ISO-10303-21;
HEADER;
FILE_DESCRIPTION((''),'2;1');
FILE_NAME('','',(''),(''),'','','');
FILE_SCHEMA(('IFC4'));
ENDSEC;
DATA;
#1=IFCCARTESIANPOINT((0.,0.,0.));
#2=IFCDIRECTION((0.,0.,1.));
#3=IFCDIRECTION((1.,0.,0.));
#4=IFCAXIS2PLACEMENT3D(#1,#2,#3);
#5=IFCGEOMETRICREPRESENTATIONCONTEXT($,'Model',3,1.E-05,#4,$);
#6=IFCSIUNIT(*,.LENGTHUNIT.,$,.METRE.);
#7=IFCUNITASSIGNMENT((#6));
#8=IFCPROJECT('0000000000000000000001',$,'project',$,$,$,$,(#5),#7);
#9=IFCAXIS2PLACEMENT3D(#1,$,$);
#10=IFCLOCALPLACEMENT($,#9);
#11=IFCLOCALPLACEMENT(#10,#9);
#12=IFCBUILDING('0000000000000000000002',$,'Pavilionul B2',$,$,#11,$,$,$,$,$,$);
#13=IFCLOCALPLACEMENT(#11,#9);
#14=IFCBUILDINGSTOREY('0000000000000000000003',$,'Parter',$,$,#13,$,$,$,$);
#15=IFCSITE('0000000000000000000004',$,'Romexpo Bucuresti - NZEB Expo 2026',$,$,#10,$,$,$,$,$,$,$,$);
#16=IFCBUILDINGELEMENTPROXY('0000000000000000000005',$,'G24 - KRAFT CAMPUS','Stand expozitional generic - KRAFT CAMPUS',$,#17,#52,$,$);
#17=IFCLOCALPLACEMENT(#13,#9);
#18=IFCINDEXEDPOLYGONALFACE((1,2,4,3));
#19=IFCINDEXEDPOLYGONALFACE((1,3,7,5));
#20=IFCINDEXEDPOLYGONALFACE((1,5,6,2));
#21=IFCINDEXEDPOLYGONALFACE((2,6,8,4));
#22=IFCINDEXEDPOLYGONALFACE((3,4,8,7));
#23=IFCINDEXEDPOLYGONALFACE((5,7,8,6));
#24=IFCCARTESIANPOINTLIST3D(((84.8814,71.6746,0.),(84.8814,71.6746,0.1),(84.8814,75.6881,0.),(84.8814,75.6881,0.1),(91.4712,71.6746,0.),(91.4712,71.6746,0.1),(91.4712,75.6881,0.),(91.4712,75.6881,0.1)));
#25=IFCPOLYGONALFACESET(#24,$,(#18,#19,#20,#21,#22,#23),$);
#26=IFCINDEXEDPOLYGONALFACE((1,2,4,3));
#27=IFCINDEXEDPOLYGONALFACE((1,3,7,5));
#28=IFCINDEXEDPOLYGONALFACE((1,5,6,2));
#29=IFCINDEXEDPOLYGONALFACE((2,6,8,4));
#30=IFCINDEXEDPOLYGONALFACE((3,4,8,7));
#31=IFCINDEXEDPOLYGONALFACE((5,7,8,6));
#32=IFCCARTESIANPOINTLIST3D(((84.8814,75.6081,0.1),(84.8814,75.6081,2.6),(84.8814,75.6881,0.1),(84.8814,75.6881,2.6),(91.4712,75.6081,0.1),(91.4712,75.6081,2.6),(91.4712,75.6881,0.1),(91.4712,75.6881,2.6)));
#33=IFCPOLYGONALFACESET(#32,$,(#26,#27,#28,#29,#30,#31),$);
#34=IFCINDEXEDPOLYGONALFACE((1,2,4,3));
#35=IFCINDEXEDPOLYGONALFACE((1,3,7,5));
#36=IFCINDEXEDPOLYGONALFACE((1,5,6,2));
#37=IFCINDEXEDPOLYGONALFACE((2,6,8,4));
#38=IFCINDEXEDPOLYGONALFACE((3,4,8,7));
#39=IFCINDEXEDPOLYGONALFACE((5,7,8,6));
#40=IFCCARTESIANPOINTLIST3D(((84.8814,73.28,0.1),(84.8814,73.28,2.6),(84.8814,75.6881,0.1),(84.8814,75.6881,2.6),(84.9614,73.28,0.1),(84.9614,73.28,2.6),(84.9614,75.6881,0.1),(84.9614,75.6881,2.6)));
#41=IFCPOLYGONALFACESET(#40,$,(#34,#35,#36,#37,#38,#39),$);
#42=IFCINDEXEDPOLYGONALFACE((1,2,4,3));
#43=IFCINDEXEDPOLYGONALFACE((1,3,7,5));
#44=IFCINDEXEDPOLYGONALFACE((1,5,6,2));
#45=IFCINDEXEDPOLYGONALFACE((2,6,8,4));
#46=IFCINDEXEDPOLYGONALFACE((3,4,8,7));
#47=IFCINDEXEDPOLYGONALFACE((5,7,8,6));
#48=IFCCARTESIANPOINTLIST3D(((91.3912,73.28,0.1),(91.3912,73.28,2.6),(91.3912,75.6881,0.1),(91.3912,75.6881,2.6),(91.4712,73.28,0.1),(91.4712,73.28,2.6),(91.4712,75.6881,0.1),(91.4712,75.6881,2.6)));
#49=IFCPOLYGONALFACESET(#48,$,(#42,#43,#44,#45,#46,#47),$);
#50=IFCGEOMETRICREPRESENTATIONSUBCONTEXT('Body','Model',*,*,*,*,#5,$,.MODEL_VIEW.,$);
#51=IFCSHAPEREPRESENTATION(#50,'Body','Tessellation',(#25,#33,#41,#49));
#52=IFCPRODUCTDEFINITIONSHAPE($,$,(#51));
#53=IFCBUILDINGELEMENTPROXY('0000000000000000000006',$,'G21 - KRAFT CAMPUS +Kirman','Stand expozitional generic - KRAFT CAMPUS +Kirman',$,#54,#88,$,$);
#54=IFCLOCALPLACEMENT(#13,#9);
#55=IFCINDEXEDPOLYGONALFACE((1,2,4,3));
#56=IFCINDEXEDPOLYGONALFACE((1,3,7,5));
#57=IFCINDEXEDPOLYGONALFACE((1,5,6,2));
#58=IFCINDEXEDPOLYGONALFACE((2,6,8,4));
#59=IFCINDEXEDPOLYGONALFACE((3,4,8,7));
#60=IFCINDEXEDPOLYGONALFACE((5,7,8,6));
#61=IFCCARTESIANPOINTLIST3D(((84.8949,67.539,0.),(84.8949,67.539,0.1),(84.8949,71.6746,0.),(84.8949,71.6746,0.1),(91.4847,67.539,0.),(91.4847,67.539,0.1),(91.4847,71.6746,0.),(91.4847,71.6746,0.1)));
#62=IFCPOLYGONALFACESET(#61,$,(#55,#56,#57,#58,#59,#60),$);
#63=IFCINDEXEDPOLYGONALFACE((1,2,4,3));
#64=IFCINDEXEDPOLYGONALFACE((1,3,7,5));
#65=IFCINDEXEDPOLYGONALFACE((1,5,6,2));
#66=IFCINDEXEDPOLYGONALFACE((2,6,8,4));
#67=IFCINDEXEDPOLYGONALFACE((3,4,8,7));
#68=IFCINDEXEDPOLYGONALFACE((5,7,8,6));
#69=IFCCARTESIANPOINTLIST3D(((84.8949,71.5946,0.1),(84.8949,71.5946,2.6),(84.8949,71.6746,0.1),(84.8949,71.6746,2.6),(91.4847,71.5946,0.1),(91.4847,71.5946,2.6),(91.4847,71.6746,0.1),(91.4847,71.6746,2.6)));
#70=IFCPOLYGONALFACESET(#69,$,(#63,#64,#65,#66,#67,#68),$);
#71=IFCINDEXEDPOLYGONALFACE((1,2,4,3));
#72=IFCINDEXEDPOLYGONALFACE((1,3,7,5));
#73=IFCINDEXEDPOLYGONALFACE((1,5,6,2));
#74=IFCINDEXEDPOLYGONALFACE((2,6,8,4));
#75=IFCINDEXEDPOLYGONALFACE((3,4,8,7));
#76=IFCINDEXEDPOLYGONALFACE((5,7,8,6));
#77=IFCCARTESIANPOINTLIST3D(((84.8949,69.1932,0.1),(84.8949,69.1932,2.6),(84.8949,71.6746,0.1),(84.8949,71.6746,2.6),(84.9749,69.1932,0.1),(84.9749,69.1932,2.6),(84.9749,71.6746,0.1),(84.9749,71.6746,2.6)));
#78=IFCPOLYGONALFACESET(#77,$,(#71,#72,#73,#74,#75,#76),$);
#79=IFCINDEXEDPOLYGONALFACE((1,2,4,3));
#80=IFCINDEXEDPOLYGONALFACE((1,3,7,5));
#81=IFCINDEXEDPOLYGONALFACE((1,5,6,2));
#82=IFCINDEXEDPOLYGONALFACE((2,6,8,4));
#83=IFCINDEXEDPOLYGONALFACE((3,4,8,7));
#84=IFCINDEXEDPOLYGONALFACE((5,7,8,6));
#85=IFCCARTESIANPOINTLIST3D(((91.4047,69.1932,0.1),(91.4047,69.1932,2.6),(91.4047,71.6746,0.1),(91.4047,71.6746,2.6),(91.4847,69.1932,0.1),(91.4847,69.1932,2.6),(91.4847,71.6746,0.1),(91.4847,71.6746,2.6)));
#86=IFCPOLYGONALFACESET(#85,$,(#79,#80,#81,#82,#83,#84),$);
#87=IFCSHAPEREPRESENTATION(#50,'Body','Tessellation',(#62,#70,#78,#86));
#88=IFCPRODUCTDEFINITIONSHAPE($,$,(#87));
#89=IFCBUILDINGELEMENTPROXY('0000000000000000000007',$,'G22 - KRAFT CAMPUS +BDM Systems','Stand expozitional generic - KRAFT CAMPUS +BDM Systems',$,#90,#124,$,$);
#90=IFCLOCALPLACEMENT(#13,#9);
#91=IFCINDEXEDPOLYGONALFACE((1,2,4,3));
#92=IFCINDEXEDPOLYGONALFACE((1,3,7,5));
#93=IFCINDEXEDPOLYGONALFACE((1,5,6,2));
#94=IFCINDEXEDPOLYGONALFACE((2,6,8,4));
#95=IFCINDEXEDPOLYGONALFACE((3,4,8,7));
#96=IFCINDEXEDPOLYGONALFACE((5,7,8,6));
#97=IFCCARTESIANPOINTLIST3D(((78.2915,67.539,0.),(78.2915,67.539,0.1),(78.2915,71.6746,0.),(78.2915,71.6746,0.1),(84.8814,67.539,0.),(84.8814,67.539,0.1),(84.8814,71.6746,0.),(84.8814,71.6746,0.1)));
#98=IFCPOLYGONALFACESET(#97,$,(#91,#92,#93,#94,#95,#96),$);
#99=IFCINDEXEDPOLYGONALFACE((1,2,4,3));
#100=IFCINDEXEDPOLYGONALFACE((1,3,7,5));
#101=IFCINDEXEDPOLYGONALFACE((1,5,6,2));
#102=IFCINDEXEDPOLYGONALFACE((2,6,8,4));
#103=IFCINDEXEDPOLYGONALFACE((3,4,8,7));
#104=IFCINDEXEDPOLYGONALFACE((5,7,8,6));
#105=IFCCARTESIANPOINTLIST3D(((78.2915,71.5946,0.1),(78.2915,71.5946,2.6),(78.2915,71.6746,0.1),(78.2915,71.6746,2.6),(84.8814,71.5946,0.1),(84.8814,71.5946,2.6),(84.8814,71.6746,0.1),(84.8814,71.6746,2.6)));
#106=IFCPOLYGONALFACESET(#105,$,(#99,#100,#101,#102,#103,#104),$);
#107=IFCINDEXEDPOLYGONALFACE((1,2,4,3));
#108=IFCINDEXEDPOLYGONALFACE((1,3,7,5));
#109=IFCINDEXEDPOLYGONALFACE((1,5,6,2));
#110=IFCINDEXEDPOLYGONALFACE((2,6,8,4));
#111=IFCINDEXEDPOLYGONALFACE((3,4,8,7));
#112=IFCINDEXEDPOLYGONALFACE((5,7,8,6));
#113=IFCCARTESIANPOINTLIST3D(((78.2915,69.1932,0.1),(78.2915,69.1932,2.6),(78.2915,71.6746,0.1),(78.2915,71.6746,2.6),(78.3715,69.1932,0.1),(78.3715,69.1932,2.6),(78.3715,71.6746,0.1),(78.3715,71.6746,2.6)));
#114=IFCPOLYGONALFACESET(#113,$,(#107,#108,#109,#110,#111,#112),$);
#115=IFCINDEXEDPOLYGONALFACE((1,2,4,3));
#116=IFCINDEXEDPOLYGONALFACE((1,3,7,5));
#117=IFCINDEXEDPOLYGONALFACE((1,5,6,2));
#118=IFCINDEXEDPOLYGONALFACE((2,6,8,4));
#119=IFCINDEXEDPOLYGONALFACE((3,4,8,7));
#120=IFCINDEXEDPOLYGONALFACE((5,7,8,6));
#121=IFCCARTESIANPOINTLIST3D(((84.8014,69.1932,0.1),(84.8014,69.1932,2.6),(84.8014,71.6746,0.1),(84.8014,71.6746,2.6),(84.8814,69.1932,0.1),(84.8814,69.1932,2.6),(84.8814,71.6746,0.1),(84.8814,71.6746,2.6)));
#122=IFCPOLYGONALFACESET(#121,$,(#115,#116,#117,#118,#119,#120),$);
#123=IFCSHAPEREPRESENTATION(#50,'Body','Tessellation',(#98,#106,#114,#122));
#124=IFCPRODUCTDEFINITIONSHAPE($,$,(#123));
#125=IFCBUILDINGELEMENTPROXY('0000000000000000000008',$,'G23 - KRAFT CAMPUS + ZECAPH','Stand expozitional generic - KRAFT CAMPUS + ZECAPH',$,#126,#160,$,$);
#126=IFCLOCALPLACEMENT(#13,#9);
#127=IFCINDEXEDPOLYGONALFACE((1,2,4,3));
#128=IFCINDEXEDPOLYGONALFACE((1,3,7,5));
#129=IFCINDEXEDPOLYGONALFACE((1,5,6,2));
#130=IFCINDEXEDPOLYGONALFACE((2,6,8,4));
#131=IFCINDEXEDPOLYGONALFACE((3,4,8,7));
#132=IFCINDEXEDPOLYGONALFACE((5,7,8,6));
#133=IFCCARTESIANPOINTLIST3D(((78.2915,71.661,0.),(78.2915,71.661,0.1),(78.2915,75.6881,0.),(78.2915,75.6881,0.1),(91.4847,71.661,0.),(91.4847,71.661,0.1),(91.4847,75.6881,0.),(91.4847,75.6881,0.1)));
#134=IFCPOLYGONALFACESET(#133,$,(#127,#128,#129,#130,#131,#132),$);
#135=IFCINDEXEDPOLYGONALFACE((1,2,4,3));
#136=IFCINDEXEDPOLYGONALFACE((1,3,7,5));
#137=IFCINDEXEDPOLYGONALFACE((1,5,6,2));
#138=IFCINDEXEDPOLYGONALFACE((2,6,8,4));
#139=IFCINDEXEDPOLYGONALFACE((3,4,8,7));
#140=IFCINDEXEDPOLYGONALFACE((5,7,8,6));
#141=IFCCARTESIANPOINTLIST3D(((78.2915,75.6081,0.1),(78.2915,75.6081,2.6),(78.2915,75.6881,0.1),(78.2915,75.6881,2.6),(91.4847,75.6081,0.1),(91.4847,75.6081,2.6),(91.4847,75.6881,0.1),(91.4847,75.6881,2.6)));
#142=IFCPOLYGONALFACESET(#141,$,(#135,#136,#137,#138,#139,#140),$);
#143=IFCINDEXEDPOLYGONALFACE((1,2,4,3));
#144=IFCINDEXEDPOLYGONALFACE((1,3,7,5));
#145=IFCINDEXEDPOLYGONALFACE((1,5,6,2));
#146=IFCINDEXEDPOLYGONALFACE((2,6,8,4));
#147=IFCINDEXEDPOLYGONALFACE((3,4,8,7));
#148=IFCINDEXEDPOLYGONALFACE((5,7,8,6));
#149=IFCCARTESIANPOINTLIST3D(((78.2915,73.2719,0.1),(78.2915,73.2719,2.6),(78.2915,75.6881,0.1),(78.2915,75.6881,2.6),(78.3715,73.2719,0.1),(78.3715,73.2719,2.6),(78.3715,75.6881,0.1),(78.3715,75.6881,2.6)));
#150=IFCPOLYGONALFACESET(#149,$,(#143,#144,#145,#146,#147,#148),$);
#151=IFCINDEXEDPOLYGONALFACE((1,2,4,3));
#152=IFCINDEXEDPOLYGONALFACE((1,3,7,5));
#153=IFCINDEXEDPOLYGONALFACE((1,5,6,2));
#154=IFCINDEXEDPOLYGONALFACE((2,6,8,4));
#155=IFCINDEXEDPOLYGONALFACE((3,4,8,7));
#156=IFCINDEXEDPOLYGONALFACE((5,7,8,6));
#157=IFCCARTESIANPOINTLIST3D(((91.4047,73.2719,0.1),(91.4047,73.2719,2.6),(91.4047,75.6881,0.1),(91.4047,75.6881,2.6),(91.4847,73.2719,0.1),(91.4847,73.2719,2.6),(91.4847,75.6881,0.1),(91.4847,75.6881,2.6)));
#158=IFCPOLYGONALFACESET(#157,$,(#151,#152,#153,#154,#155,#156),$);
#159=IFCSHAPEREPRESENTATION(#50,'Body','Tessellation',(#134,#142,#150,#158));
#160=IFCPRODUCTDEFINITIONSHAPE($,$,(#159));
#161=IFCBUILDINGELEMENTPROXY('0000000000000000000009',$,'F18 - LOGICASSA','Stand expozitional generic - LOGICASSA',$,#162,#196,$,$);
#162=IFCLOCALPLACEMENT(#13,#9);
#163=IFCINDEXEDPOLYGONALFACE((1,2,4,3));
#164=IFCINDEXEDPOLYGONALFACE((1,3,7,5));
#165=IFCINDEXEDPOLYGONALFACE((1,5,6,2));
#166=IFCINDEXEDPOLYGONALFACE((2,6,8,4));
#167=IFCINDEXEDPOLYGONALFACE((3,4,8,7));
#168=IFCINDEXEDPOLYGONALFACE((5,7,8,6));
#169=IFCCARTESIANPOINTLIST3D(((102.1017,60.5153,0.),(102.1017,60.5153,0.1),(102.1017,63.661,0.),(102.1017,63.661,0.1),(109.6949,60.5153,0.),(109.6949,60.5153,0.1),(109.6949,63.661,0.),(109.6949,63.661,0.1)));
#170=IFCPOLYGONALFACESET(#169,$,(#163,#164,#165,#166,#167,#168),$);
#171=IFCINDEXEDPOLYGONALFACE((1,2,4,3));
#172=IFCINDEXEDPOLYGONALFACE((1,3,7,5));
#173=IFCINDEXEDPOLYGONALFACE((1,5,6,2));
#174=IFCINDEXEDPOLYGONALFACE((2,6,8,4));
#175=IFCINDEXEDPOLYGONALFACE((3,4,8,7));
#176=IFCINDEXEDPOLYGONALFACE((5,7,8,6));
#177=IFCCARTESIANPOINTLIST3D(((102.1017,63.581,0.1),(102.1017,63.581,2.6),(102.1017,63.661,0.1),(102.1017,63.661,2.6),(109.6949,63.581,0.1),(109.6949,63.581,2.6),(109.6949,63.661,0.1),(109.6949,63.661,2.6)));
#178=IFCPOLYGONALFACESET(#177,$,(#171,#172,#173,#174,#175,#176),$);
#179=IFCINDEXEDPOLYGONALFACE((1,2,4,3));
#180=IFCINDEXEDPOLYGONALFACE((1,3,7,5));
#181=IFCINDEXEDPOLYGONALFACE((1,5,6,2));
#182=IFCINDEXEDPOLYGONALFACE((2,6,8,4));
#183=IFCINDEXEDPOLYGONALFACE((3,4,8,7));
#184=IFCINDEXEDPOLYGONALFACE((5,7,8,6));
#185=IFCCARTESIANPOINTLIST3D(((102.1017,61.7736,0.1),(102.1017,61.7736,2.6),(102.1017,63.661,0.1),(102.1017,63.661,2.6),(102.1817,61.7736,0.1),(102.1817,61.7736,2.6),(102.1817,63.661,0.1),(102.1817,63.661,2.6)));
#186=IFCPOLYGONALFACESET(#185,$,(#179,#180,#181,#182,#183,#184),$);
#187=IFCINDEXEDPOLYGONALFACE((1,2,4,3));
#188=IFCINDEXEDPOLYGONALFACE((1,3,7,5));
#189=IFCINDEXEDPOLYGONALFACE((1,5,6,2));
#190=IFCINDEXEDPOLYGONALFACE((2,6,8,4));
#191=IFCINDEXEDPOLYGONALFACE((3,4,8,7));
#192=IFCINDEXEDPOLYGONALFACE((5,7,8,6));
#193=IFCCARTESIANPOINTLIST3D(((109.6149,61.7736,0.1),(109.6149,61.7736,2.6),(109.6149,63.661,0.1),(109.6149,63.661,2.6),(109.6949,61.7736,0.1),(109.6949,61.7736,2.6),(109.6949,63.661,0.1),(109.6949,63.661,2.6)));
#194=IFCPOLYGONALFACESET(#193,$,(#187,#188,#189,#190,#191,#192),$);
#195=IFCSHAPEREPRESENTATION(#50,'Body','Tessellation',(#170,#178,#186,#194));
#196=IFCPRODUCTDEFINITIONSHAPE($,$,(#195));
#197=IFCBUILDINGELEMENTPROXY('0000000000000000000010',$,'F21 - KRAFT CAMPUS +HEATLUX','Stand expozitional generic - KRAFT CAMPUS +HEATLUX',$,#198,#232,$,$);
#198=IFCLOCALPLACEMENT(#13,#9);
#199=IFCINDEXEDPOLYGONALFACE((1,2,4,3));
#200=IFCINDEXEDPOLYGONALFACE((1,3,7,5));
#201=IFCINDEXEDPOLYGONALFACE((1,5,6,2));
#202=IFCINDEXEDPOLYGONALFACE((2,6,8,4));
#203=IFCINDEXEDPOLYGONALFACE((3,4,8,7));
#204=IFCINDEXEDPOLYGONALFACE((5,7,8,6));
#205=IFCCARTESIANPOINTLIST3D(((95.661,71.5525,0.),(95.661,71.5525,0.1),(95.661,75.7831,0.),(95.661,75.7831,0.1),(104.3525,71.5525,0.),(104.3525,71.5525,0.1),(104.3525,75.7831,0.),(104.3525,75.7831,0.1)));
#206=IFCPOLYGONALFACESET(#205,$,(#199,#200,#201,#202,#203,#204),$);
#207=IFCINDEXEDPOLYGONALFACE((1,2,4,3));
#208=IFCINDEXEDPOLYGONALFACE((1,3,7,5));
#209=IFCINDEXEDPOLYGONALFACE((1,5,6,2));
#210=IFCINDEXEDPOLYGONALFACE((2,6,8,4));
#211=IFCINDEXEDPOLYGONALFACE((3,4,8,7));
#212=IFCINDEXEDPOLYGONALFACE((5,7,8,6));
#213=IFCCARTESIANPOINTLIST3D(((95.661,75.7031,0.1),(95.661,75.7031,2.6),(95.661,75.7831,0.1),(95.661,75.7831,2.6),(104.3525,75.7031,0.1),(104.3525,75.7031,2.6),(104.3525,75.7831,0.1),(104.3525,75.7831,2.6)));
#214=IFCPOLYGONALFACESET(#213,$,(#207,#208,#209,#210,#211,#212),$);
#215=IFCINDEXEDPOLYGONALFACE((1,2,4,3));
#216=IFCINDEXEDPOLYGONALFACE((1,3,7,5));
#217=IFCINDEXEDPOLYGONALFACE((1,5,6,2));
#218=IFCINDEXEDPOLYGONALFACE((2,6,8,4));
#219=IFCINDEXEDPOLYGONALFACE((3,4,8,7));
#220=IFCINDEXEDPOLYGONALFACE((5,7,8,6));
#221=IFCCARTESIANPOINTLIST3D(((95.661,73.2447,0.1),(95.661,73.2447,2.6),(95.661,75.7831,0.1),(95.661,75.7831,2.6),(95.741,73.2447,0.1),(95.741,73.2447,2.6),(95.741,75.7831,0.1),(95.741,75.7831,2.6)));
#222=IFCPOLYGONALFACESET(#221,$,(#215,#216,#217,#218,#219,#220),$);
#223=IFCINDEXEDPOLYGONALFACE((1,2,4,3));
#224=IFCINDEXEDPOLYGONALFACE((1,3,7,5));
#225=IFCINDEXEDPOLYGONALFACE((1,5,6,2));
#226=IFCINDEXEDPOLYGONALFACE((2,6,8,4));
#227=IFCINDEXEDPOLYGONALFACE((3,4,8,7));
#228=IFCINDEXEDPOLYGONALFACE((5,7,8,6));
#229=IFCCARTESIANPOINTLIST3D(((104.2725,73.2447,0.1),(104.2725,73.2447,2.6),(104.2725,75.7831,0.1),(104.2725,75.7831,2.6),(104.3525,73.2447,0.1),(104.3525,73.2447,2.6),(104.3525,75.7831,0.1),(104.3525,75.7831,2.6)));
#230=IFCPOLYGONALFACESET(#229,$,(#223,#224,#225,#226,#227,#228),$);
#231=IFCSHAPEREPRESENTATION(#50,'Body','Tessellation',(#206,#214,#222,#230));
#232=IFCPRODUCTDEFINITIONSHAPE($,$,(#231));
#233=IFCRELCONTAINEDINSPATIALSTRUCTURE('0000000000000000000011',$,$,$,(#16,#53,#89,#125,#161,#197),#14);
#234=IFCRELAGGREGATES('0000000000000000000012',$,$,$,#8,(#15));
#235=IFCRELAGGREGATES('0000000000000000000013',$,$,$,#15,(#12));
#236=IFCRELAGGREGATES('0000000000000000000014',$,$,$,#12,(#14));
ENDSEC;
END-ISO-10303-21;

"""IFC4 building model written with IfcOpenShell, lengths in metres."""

from ifc_helpers import new_model, si_unit, frame, frame_2d, origin, origin_with_axes, place, context, subcontext, project, spatial, rectangle, extrude, element, save


model = new_model("IFC4")

# Units and contexts
model_context = context("Model", 3, precision=1e-05, world=origin_with_axes())
body_context = subcontext(model_context, "Body", "Model", "MODEL_VIEW")
ifc_project = project(units=[si_unit("LENGTHUNIT", "METRE")], contexts=[model_context])

# Site, building, storey
site_placement = place(None, origin())
site = spatial("IfcSite", under=ifc_project, at=site_placement, Name="Romexpo Bucuresti - NZEB Expo 2026")
building_placement = place(site_placement, origin())
building = spatial("IfcBuilding", under=site, at=building_placement, Name="Pavilionul B2")
storey_placement = place(building_placement, origin())
storey = spatial("IfcBuildingStorey", under=building, at=storey_placement, Name="Parter")

# Building element proxies
proxy_1_placement = place(storey_placement, frame((84.8814, 71.6746, 0.0), z_axis=(0.0, 0.0, 1.0), x_axis=(1.0, 0.0, 0.0)))
element("IfcBuildingElementProxy", 1, at=proxy_1_placement, inside=storey, Name="G24 - KRAFT CAMPUS", Description="Stand expozitional generic - KRAFT CAMPUS", context=body_context, shape_type="SweptSolid", body=[
    extrude(rectangle(XDim=6.5898, YDim=4.0136, at=frame_2d((3.2949, 2.0068))), origin(), (0.0, 0.0, 1.0), 0.1),
    extrude(rectangle(XDim=6.5898, YDim=0.08, at=frame_2d((3.2949, 3.9736))), frame((0.0, 0.0, 0.1)), (0.0, 0.0, 1.0), 2.5),
    extrude(rectangle(XDim=0.08, YDim=2.4081, at=frame_2d((0.04, 2.8095))), frame((0.0, 0.0, 0.1)), (0.0, 0.0, 1.0), 2.5),
    extrude(rectangle(XDim=0.08, YDim=2.4081, at=frame_2d((6.5498, 2.8095))), frame((0.0, 0.0, 0.1)), (0.0, 0.0, 1.0), 2.5),
])
for number, where, z_axis, x_axis, name, description in (
    (2, (84.8949, 67.539, 0.0), (0.0, 0.0, 1.0), (1.0, 0.0, 0.0), "G21 - KRAFT CAMPUS +Kirman", "Stand expozitional generic - KRAFT CAMPUS +Kirman"),
    (3, (78.2915, 67.539, 0.0), (0.0, 0.0, 1.0), (1.0, 0.0, 0.0), "G22 - KRAFT CAMPUS +BDM Systems", "Stand expozitional generic - KRAFT CAMPUS +BDM Systems"),
):
    element("IfcBuildingElementProxy", number, at=place(storey_placement, frame(where, z_axis=z_axis, x_axis=x_axis)), inside=storey, Name=name, Description=description, context=body_context, shape_type="SweptSolid", body=[
        extrude(rectangle(XDim=6.5898, YDim=4.1356, at=frame_2d((3.2949, 2.0678))), origin(), (0.0, 0.0, 1.0), 0.1),
        extrude(rectangle(XDim=6.5898, YDim=0.08, at=frame_2d((3.2949, 4.0956))), frame((0.0, 0.0, 0.1)), (0.0, 0.0, 1.0), 2.5),
        extrude(rectangle(XDim=0.08, YDim=2.4814, at=frame_2d((0.04, 2.8949))), frame((0.0, 0.0, 0.1)), (0.0, 0.0, 1.0), 2.5),
        extrude(rectangle(XDim=0.08, YDim=2.4814, at=frame_2d((6.5498, 2.8949))), frame((0.0, 0.0, 0.1)), (0.0, 0.0, 1.0), 2.5),
    ])
proxy_2_placement = place(storey_placement, frame((78.2915, 71.661, 0.0), z_axis=(0.0, 0.0, 1.0), x_axis=(1.0, 0.0, 0.0)))
element("IfcBuildingElementProxy", 4, at=proxy_2_placement, inside=storey, Name="G23 - KRAFT CAMPUS + ZECAPH", Description="Stand expozitional generic - KRAFT CAMPUS + ZECAPH", context=body_context, shape_type="SweptSolid", body=[
    extrude(rectangle(XDim=13.1932, YDim=4.0271, at=frame_2d((6.5966, 2.0136))), origin(), (0.0, 0.0, 1.0), 0.1),
    extrude(rectangle(XDim=13.1932, YDim=0.08, at=frame_2d((6.5966, 3.9871))), frame((0.0, 0.0, 0.1)), (0.0, 0.0, 1.0), 2.5),
    extrude(rectangle(XDim=0.08, YDim=2.4163, at=frame_2d((0.04, 2.819))), frame((0.0, 0.0, 0.1)), (0.0, 0.0, 1.0), 2.5),
    extrude(rectangle(XDim=0.08, YDim=2.4163, at=frame_2d((13.1532, 2.819))), frame((0.0, 0.0, 0.1)), (0.0, 0.0, 1.0), 2.5),
])
proxy_3_placement = place(storey_placement, frame((102.1017, 60.5153, 0.0), z_axis=(0.0, 0.0, 1.0), x_axis=(1.0, 0.0, 0.0)))
element("IfcBuildingElementProxy", 5, at=proxy_3_placement, inside=storey, Name="F18 - LOGICASSA", Description="Stand expozitional generic - LOGICASSA", context=body_context, shape_type="SweptSolid", body=[
    extrude(rectangle(XDim=7.5932, YDim=3.1458, at=frame_2d((3.7966, 1.5729))), origin(), (0.0, 0.0, 1.0), 0.1),
    extrude(rectangle(XDim=7.5932, YDim=0.08, at=frame_2d((3.7966, 3.1058))), frame((0.0, 0.0, 0.1)), (0.0, 0.0, 1.0), 2.5),
    extrude(rectangle(XDim=0.08, YDim=1.8875, at=frame_2d((0.04, 2.202))), frame((0.0, 0.0, 0.1)), (0.0, 0.0, 1.0), 2.5),
    extrude(rectangle(XDim=0.08, YDim=1.8875, at=frame_2d((7.5532, 2.202))), frame((0.0, 0.0, 0.1)), (0.0, 0.0, 1.0), 2.5),
])
for number, where, z_axis, x_axis, name in (
    (6, (95.661, 71.5525, 0.0), (0.0, 0.0, 1.0), (1.0, 0.0, 0.0), "F21 - KRAFT CAMPUS +HEATLUX"),
):
    element("IfcBuildingElementProxy", number, at=place(storey_placement, frame(where, z_axis=z_axis, x_axis=x_axis)), inside=storey, Name=name, Description="Stand expozitional generic - KRAFT CAMPUS +HEATLUX", context=body_context, shape_type="SweptSolid", body=[
        extrude(rectangle(XDim=8.6915, YDim=4.2305, at=frame_2d((4.3458, 2.1153))), origin(), (0.0, 0.0, 1.0), 0.1),
        extrude(rectangle(XDim=8.6915, YDim=0.08, at=frame_2d((4.3458, 4.1905))), frame((0.0, 0.0, 0.1)), (0.0, 0.0, 1.0), 2.5),
        extrude(rectangle(XDim=0.08, YDim=2.5383, at=frame_2d((0.04, 2.9614))), frame((0.0, 0.0, 0.1)), (0.0, 0.0, 1.0), 2.5),
        extrude(rectangle(XDim=0.08, YDim=2.5383, at=frame_2d((8.6515, 2.9614))), frame((0.0, 0.0, 0.1)), (0.0, 0.0, 1.0), 2.5),
    ])

save(model, "model.ifc")
